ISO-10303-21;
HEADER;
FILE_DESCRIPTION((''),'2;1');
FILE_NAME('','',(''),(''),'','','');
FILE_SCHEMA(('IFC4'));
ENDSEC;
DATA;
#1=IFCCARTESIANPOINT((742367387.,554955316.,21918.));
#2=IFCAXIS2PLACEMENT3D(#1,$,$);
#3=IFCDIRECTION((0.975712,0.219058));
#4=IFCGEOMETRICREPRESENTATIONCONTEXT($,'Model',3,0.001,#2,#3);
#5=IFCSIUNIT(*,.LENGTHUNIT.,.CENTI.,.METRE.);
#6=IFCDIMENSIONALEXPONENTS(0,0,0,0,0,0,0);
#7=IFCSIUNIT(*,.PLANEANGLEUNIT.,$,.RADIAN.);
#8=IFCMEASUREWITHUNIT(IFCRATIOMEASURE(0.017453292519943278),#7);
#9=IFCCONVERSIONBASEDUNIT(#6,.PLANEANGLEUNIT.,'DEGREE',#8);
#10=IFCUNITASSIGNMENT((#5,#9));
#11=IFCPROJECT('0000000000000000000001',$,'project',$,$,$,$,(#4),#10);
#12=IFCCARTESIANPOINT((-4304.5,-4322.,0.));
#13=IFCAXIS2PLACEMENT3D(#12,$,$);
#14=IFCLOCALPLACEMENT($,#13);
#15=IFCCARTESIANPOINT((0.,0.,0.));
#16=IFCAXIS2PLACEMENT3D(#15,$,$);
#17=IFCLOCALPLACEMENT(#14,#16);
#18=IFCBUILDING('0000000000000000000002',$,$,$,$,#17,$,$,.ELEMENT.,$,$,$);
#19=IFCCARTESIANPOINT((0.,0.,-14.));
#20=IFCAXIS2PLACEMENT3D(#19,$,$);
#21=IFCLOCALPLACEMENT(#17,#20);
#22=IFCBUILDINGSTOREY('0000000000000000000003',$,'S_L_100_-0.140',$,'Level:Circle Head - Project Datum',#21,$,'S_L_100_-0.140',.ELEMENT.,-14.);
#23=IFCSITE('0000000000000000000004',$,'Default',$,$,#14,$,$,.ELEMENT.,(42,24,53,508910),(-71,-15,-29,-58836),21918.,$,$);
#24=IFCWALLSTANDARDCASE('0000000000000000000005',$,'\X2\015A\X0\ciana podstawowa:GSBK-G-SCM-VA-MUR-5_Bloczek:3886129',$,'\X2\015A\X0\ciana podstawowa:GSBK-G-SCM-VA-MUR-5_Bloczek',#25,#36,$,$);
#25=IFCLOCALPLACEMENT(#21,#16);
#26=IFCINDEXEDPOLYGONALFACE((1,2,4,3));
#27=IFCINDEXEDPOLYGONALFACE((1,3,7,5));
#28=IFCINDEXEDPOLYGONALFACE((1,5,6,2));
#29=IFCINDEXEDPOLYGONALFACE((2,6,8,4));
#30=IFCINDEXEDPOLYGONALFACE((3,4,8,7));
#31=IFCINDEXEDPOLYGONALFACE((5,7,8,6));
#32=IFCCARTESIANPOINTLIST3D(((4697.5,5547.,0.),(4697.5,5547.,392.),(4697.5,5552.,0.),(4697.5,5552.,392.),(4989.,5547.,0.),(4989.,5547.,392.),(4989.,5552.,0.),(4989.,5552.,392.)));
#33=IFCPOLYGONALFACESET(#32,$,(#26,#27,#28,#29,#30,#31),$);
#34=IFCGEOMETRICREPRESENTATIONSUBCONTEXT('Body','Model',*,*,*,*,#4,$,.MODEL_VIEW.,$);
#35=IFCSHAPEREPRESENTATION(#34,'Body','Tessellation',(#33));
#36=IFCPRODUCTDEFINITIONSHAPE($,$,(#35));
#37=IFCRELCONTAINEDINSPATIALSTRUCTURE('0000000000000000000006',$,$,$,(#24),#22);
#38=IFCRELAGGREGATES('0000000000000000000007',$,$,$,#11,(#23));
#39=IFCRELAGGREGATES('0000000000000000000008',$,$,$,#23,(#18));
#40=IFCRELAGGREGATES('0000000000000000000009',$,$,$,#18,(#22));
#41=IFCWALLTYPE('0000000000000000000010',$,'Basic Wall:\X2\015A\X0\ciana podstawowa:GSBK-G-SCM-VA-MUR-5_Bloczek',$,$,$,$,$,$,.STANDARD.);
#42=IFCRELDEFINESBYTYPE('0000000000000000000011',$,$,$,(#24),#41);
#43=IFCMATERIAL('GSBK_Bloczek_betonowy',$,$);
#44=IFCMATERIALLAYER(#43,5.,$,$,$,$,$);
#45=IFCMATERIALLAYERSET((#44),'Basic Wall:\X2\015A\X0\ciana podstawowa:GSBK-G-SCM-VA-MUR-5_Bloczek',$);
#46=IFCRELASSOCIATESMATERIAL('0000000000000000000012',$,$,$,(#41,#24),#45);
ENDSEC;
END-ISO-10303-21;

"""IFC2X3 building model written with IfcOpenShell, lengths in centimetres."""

from ifc_helpers import new_model, entity, si_unit, converted_unit, direction, frame, frame_2d, origin, place, context, subcontext, project, spatial, rectangle, extrude, material, layer, layer_set, layer_usage, type_object, element, save


model = new_model("IFC2X3")

# Units and contexts
model_context = context("Model", 3, precision=0.001, world=frame((742367387.0, 554955316.0, 21918.0)), true_north=direction((0.975712, 0.219058)))
body_context = subcontext(model_context, "Body", "Model", "MODEL_VIEW")
ifc_project = project(units=[si_unit("LENGTHUNIT", "METRE", prefix="CENTI"), converted_unit("PLANEANGLEUNIT", "DEGREE", entity("IfcRatioMeasure", 0.017453292519943278), si_unit("PLANEANGLEUNIT", "RADIAN"), dimensions=[0, 0, 0, 0, 0, 0, 0])], contexts=[model_context])

# Site, building, storey
site_placement = place(None, frame((-4304.5, -4322.0, 0.0)))
site = spatial("IfcSite", under=ifc_project, at=site_placement, Name="Default", CompositionType="ELEMENT", RefLatitude=(42, 24, 53, 508910), RefLongitude=(-71, -15, -29, -58836), RefElevation=21918.0)
building_placement = place(site_placement, origin())
building = spatial("IfcBuilding", under=site, at=building_placement, CompositionType="ELEMENT")
storey_placement = place(building_placement, frame((0.0, 0.0, -14.0)))
storey = spatial("IfcBuildingStorey", under=building, at=storey_placement, Name="S_L_100_-0.140", ObjectType="Level:Circle Head - Project Datum", LongName="S_L_100_-0.140", CompositionType="ELEMENT", Elevation=-14.0)

# Shared definitions
ifc_material_1 = material(Name="GSBK_Bloczek_betonowy")

# Shared definitions
ifc_layer_1 = layer(ifc_material_1, 5.0)
ifc_layer_set_1 = layer_set([ifc_layer_1], Name="Basic Wall:Ściana podstawowa:GSBK-G-SCM-VA-MUR-5_Bloczek")
wall_type_1 = type_object("IfcWallType", Name="Basic Wall:Ściana podstawowa:GSBK-G-SCM-VA-MUR-5_Bloczek", PredefinedType="STANDARD", material=ifc_layer_set_1)

# Wall
ifc_layer_usage_1 = layer_usage(ifc_layer_set_1, "AXIS2", "NEGATIVE", 2.5)
wall_1_placement = place(storey_placement, frame((4697.5, 5549.5, 0.0)))
element("IfcWallStandardCase", 1, at=wall_1_placement, inside=storey, type_object=wall_type_1, material=ifc_layer_usage_1, Name="Ściana podstawowa:GSBK-G-SCM-VA-MUR-5_Bloczek:3886129", ObjectType="Ściana podstawowa:GSBK-G-SCM-VA-MUR-5_Bloczek", context=body_context, shape_type="SweptSolid", body=[
    extrude(rectangle(XDim=291.5, YDim=5.0, at=frame_2d((145.75, 0.0), x_axis=(-1.0, 0.0))), origin(), (0.0, 0.0, 1.0), 392.0),
])

save(model, "model.ifc")
